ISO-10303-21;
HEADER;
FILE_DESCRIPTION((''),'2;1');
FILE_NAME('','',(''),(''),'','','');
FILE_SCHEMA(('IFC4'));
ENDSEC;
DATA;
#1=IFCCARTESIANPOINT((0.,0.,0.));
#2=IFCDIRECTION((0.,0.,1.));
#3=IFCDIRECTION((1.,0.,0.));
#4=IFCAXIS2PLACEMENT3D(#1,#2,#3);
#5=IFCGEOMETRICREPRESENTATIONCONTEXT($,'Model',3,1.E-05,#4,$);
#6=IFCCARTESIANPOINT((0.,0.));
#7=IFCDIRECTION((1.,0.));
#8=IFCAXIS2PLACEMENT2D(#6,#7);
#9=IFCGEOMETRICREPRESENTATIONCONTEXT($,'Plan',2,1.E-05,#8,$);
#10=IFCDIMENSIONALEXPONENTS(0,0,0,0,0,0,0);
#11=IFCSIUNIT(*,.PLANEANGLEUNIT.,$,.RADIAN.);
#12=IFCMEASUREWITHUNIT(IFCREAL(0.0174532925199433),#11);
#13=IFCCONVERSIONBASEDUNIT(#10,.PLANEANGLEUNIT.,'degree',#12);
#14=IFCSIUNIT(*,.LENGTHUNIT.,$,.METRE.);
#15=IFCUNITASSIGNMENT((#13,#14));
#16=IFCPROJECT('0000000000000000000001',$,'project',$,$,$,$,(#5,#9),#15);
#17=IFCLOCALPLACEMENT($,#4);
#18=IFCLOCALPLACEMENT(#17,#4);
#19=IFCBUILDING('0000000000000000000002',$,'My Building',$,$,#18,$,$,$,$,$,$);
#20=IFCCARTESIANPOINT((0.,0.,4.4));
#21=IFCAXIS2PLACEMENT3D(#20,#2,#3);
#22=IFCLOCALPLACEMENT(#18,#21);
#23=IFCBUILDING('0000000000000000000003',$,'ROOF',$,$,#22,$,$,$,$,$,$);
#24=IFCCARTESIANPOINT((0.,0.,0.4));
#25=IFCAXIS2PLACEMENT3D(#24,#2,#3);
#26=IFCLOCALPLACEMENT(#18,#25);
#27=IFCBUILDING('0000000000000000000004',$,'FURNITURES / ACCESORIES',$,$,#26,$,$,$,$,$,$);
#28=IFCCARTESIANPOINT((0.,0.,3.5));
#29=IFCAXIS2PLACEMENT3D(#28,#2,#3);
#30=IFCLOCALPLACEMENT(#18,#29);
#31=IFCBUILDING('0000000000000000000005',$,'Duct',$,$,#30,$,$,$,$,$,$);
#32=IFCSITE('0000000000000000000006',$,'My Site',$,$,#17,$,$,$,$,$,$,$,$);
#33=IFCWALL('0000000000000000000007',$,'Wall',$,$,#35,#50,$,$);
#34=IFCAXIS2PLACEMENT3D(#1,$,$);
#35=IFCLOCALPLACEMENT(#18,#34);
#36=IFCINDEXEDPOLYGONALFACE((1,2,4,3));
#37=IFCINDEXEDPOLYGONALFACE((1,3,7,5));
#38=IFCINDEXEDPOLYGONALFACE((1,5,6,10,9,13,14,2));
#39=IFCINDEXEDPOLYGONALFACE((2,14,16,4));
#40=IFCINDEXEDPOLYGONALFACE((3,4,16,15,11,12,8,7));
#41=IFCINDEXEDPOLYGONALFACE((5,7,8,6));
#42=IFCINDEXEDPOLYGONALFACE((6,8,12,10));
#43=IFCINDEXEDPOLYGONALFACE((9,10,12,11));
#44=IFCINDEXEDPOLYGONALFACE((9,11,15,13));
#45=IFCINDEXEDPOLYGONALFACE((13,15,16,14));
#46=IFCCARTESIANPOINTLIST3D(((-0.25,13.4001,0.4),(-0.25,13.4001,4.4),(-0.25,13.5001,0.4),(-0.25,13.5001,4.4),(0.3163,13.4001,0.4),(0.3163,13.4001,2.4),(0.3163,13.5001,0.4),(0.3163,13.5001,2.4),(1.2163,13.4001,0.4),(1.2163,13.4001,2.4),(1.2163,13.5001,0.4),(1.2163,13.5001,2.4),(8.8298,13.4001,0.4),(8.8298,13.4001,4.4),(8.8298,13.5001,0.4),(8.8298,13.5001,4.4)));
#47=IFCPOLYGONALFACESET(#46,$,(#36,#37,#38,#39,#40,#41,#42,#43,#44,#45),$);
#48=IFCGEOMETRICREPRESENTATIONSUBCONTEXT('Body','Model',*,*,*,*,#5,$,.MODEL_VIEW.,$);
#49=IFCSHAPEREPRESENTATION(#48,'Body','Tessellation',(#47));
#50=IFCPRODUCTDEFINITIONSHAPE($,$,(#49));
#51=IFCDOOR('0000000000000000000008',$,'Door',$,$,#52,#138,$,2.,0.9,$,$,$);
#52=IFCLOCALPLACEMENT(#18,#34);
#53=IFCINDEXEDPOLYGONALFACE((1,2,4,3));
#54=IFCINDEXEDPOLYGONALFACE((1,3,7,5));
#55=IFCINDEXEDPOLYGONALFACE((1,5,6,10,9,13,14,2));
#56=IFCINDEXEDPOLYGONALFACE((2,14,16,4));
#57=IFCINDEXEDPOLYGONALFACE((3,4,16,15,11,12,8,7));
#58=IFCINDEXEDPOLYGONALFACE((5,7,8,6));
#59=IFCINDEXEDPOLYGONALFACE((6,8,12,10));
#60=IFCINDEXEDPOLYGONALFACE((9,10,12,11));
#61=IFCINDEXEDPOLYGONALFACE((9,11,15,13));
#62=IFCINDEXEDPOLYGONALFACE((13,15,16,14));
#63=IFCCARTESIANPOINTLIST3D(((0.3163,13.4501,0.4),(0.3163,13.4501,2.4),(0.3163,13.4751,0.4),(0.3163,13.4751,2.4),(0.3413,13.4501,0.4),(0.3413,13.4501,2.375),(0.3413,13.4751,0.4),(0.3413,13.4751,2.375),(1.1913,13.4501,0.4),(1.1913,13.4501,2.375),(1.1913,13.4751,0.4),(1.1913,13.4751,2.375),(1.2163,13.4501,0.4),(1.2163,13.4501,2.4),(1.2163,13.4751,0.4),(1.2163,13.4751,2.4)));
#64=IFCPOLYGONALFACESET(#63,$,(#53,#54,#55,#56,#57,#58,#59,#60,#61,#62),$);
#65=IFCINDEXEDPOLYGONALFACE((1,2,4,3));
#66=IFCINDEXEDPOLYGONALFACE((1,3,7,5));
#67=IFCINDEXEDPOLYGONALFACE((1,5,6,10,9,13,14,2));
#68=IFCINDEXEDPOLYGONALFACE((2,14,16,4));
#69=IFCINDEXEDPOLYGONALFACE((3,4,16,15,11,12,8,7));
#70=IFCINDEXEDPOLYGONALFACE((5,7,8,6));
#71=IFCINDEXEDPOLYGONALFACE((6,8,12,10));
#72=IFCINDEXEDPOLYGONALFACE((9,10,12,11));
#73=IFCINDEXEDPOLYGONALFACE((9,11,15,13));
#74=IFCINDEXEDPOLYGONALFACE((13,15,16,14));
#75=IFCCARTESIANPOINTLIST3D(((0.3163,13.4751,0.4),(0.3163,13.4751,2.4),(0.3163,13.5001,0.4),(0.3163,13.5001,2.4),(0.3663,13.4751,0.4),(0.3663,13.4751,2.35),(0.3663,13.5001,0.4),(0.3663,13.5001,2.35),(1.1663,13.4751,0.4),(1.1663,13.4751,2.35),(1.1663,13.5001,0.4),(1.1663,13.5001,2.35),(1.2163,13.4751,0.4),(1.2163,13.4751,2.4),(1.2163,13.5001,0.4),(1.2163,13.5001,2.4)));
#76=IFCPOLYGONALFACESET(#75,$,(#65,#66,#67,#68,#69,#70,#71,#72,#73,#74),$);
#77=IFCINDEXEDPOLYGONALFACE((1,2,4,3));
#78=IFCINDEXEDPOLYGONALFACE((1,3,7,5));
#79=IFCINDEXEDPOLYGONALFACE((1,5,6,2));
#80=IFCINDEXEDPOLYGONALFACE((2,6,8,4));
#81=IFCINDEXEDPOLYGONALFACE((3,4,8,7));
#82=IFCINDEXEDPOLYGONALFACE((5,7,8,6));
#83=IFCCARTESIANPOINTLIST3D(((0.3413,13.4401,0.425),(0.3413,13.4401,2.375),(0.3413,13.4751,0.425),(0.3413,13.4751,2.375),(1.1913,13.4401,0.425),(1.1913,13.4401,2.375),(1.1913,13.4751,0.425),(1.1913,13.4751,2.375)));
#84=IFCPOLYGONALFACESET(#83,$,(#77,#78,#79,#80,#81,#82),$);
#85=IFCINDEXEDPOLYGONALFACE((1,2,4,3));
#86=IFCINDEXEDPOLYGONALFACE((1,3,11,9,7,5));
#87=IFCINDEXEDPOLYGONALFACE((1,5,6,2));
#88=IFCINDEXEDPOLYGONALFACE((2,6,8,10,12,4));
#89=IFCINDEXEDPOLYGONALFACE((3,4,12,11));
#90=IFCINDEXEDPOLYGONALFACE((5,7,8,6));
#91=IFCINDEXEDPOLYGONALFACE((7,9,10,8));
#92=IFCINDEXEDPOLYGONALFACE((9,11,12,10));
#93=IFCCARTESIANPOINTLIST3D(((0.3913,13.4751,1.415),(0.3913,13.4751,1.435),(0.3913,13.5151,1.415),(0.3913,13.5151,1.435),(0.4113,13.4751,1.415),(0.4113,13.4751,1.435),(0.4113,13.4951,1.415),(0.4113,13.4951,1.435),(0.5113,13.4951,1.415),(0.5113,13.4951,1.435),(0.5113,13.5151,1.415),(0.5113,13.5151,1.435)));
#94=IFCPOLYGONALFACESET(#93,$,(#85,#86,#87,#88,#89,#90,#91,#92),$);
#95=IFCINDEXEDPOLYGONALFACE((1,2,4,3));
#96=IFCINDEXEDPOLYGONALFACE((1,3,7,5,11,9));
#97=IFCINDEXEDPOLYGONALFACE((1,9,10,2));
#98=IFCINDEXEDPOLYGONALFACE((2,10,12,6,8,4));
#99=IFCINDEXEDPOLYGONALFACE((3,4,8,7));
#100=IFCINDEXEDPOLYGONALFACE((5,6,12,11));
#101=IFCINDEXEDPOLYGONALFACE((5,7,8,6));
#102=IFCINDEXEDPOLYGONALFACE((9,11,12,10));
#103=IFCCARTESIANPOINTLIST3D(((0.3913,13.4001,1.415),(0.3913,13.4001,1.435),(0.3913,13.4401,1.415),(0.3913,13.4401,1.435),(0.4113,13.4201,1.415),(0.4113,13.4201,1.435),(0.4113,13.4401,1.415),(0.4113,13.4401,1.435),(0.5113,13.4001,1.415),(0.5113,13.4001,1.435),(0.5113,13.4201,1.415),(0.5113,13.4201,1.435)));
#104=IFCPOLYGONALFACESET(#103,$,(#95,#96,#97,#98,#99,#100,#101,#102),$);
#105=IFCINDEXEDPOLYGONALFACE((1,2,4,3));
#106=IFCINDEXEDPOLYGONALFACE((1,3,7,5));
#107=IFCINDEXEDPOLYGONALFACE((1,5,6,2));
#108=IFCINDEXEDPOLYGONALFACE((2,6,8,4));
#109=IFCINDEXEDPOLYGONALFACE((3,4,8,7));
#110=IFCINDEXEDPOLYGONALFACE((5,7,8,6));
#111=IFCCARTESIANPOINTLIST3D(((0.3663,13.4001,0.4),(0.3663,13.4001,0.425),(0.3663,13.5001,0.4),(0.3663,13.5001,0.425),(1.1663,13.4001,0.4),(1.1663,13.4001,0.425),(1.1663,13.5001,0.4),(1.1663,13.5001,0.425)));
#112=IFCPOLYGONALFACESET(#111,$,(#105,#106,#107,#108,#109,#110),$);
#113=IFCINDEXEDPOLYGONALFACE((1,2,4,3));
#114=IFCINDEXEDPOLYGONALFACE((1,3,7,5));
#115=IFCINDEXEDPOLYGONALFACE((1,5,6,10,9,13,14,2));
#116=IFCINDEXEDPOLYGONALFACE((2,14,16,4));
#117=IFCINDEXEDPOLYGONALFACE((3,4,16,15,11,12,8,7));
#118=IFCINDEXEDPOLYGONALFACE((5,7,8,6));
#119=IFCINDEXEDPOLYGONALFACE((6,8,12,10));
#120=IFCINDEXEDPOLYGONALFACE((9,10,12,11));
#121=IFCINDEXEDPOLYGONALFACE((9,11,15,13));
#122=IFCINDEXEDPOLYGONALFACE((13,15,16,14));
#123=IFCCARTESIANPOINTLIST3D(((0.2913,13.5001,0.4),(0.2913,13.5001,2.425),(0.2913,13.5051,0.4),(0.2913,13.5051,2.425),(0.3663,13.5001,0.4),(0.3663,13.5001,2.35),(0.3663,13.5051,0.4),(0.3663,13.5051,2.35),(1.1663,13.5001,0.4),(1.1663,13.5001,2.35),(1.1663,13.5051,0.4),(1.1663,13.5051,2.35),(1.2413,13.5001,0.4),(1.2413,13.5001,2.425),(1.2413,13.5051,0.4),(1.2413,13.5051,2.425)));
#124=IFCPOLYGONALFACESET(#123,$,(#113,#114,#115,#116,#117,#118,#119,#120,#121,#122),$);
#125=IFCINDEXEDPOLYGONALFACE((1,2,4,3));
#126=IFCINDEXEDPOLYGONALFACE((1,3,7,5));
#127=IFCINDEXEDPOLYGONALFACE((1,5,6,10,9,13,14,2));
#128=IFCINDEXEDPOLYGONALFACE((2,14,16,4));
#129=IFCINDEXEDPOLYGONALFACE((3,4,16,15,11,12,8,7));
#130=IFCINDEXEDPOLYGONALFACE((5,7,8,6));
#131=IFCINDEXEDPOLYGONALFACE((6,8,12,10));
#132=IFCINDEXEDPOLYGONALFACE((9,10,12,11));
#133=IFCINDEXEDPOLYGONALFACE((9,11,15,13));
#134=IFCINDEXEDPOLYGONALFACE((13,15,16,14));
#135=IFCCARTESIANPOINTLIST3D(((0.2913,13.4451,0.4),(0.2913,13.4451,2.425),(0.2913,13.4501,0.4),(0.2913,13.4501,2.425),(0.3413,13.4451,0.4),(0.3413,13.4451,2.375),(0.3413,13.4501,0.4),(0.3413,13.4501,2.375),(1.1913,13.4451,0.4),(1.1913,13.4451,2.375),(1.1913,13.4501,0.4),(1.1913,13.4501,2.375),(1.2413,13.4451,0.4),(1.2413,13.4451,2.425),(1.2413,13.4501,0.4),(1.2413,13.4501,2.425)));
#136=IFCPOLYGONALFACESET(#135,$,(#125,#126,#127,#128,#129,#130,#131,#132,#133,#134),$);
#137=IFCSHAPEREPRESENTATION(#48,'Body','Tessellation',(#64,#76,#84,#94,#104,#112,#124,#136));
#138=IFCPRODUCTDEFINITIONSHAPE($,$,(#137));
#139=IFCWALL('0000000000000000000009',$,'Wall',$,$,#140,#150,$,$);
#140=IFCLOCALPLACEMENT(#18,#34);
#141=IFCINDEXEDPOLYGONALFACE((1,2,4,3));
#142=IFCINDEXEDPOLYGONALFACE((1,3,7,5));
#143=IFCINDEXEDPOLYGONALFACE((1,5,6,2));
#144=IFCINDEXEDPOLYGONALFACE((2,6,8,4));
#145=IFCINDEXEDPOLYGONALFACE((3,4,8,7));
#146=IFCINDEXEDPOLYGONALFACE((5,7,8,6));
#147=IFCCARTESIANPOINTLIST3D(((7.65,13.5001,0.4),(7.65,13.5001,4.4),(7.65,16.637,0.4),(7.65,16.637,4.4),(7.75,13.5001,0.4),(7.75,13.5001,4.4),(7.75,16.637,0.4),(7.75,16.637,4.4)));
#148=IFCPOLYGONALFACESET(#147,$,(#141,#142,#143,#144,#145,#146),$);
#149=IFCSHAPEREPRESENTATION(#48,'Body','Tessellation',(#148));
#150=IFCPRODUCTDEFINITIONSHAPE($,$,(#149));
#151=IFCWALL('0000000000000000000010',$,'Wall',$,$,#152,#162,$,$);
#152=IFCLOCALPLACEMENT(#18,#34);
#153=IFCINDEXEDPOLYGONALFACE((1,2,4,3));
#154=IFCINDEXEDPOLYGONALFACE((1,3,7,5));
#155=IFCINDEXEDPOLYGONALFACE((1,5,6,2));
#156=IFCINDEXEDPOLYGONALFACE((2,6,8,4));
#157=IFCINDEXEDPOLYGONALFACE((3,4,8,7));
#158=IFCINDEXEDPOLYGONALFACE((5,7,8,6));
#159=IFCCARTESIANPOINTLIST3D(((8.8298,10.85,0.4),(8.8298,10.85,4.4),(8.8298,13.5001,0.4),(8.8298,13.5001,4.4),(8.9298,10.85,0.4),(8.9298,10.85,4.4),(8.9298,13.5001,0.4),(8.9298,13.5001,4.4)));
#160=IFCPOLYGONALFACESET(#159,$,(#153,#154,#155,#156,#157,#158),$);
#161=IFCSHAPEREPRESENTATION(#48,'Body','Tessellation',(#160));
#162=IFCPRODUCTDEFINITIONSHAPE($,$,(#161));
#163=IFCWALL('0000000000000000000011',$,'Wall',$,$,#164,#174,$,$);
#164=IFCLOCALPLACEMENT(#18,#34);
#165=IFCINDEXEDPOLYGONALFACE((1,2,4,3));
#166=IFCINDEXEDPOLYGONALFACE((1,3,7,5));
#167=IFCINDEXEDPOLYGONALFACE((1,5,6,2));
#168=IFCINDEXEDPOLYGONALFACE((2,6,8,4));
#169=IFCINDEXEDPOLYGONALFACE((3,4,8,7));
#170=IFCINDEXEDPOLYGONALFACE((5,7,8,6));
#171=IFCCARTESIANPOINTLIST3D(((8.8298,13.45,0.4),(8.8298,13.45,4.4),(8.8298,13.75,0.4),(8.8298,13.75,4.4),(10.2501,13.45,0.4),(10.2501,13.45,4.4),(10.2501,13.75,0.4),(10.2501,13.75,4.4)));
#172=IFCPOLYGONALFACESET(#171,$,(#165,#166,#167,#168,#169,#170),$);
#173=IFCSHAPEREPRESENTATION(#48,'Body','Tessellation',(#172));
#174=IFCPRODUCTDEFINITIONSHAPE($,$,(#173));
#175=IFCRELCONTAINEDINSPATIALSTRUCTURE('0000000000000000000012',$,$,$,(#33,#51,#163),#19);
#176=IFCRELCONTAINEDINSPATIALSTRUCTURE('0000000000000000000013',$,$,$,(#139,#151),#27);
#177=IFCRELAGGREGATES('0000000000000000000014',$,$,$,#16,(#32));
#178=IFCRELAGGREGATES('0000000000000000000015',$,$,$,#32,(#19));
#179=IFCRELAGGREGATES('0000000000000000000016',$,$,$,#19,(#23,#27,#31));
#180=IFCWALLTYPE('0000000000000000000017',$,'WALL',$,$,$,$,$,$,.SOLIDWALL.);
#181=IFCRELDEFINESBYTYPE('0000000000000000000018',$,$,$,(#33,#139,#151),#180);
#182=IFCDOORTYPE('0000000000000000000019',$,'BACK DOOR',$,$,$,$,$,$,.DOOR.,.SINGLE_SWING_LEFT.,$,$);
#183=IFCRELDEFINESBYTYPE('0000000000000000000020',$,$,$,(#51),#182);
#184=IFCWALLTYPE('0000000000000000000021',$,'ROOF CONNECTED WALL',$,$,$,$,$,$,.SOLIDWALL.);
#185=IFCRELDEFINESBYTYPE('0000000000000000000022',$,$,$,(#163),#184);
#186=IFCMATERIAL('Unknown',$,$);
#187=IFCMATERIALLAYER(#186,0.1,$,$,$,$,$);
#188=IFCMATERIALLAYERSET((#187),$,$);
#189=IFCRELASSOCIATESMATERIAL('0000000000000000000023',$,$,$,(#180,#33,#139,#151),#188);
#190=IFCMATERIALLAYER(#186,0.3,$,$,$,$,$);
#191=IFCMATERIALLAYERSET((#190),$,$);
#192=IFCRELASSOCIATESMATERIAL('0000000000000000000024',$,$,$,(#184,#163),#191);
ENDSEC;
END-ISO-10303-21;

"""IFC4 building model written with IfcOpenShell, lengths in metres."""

from ifc_helpers import new_model, entity, si_unit, converted_unit, frame, origin_with_axes, origin_2d_with_axis, place, context, subcontext, project, spatial, line, indexed_curve, outline, extrude, shape, source, transform, mapped, material, layer, layer_set, layer_usage, type_object, type_shapes, element, fill, save


model = new_model("IFC4")

# Units and contexts
model_context = context("Model", 3, precision=1e-05, world=origin_with_axes())
plan_context = context("Plan", 2, precision=1e-05, world=origin_2d_with_axis())
body_context_1 = subcontext(model_context, "Body", "Model", "MODEL_VIEW")
body_context_2 = subcontext(plan_context, "Body", "Plan", "PLAN_VIEW")
ifc_project = project(units=[converted_unit("PLANEANGLEUNIT", "degree", entity("IfcReal", 0.0174532925199433), si_unit("PLANEANGLEUNIT", "RADIAN"), dimensions=[0, 0, 0, 0, 0, 0, 0]), si_unit("LENGTHUNIT", "METRE")], contexts=[model_context, plan_context])

# Site, building
site_placement = place(None, origin_with_axes())
site = spatial("IfcSite", under=ifc_project, at=site_placement, Name="My Site")
building_1_placement = place(site_placement, origin_with_axes())
building_1 = spatial("IfcBuilding", under=site, at=building_1_placement, Name="My Building")

# Shared definitions
ifc_material = material(Name="Unknown")

# Shared definitions
building_2_placement = place(building_1_placement, frame((0.0, 0.0, 4.4), z_axis=(0.0, 0.0, 1.0), x_axis=(1.0, 0.0, 0.0)))
building_2 = spatial("IfcBuilding", under=building_1, at=building_2_placement, Name="ROOF")

# Shared definitions
building_3_placement = place(building_1_placement, frame((0.0, 0.0, 0.4), z_axis=(0.0, 0.0, 1.0), x_axis=(1.0, 0.0, 0.0)))
building_3 = spatial("IfcBuilding", under=building_1, at=building_3_placement, Name="FURNITURES / ACCESORIES")

# Wall, opening, door
ifc_layer_1 = layer(ifc_material, 0.1)
ifc_layer_set_1 = layer_set([ifc_layer_1])
ifc_layer_usage_1 = layer_usage(ifc_layer_set_1, "AXIS2", "POSITIVE", 0.0)
wall_type_1 = type_object("IfcWallType", Name="WALL", PredefinedType="SOLIDWALL", material=ifc_layer_set_1)
wall_1_placement = place(building_1_placement, frame((8.8298, 13.5001, 0.4), z_axis=(0.0, 0.0, 1.0), x_axis=(-1.0, 0.0, 0.0)))
wall_1 = element("IfcWall", 1, at=wall_1_placement, inside=building_1, type_object=wall_type_1, material=ifc_layer_usage_1, Name="Wall", context=body_context_1, shape_type="SweptSolid", body=[
    extrude(outline(indexed_curve([(0.0, 0.0), (0.0, 0.1), (9.0798, 0.1), (9.0798, 0.0)], segments=[line(1, 2, 3, 4, 1)])), origin_with_axes(), (0.0, 0.0, 1.0), 4.0),
])
shared_shape_1 = source(origin_with_axes(), body_context_1, "Body", "SweptSolid", [
    extrude(outline(indexed_curve([(0.0, 0.0), (0.9, 0.0), (0.9, 2.0), (0.0, 2.0)], segments=[line(1, 2, 3, 4, 1)])), frame((0.0, -0.6, 0.0), z_axis=(0.0, -1.0, 0.0), x_axis=(1.0, 0.0, 0.0)), (0.0, 0.0, -1.0), 1.2),
])
opening_placement = place(wall_1_placement, frame((7.6135, 0.0, 0.0), z_axis=(0.0, 0.0, 1.0), x_axis=(1.0, 0.0, 0.0)))
opening = element("IfcOpeningElement", 2, at=opening_placement, cuts=wall_1, PredefinedType="OPENING", context=body_context_1, shape_type="MappedRepresentation", body=[
    mapped(shared_shape_1, transform((0.0, 0.0, 0.0), x_axis=(1.0, 0.0, 0.0), y_axis=(0.0, 1.0, 0.0), z_axis=(0.0, 0.0, 1.0), scale=1.0)),
])
door_type = type_object("IfcDoorType", Name="BACK DOOR", OperationType="SINGLE_SWING_LEFT", PredefinedType="DOOR")
shared_shape_2 = source(origin_with_axes(), body_context_1, "Body", "SweptSolid", [
    extrude(outline(indexed_curve([(0.0, 0.0), (0.0, 2.0), (0.9, 2.0), (0.9, 0.0), (0.875, 0.0), (0.875, 1.975), (0.025, 1.975), (0.025, 0.0)], segments=[line(1, 2, 3, 4, 5, 6, 7, 8, 1)])), frame((0.0, 0.025, 0.0), z_axis=(0.0, -1.0, 0.0), x_axis=(1.0, 0.0, 0.0)), (0.0, 0.0, -1.0), 0.025),
    extrude(outline(indexed_curve([(0.0, 0.0), (0.0, 2.0), (0.9, 2.0), (0.9, 0.0), (0.85, 0.0), (0.85, 1.95), (0.05, 1.95), (0.05, 0.0)], segments=[line(1, 2, 3, 4, 5, 6, 7, 8, 1)])), frame((0.0, 0.0, 0.0), z_axis=(0.0, -1.0, 0.0), x_axis=(1.0, 0.0, 0.0)), (0.0, 0.0, -1.0), 0.025),
    extrude(outline(indexed_curve([(0.0, 0.0), (0.85, 0.0), (0.85, 0.035), (0.0, 0.035)], segments=[line(1, 2, 3, 4, 1)])), frame((0.025, 0.025, 0.025), z_axis=(0.0, 0.0, 1.0), x_axis=(1.0, 0.0, 0.0)), (0.0, 0.0, 1.0), 1.95),
    extrude(outline(indexed_curve([(0.0, 0.0), (0.0, -0.04), (-0.12, -0.04), (-0.12, -0.02), (-0.02, -0.02), (-0.02, 0.0)], segments=[line(1, 2, 3, 4, 5, 6, 1)])), frame((0.825, 0.025, 1.015), z_axis=(0.0, 0.0, 1.0), x_axis=(1.0, 0.0, 0.0)), (0.0, 0.0, 1.0), 0.02),
    extrude(outline(indexed_curve([(0.0, 0.0), (0.0, 0.04), (-0.12, 0.04), (-0.12, 0.02), (-0.02, 0.02), (-0.02, 0.0)], segments=[line(1, 2, 3, 4, 5, 6, 1)])), frame((0.825, 0.06, 1.015), z_axis=(0.0, 0.0, 1.0), x_axis=(1.0, 0.0, 0.0)), (0.0, 0.0, 1.0), 0.02),
    extrude(outline(indexed_curve([(0.0, 0.0), (0.8, 0.0), (0.8, 0.1), (0.0, 0.1)], segments=[line(1, 2, 3, 4, 1)])), frame((0.05, 0.0, 0.0), z_axis=(0.0, 0.0, 1.0), x_axis=(1.0, 0.0, 0.0)), (0.0, 0.0, 1.0), 0.025),
    extrude(outline(indexed_curve([(0.0, 0.0), (0.0, 2.025), (0.95, 2.025), (0.95, 0.0), (0.875, 0.0), (0.875, 1.95), (0.075, 1.95), (0.075, 0.0)], segments=[line(1, 2, 3, 4, 5, 6, 7, 8, 1)])), frame((-0.025, -0.005, 0.0), z_axis=(0.0, -1.0, 0.0), x_axis=(1.0, 0.0, 0.0)), (0.0, 0.0, -1.0), 0.005),
    extrude(outline(indexed_curve([(0.0, 0.0), (0.0, 2.025), (0.95, 2.025), (0.95, 0.0), (0.9, 0.0), (0.9, 1.975), (0.05, 1.975), (0.05, 0.0)], segments=[line(1, 2, 3, 4, 5, 6, 7, 8, 1)])), frame((-0.025, 0.05, 0.0), z_axis=(0.0, -1.0, 0.0), x_axis=(1.0, 0.0, 0.0)), (0.0, 0.0, -1.0), 0.005),
])
shared_shape_3 = source(origin_with_axes(), body_context_2, "Body", "Curve2D", [
    entity("IfcIndexedPolyCurve", entity("IfcCartesianPointList2D", [[0.0, 0.0], [0.0, 0.05], [0.025, 0.05], [0.025, 0.025], [0.05, 0.025], [0.05, 0.0]]), [entity("IfcLineIndex", [1, 2, 3, 4, 5, 6, 1])]),
    entity("IfcIndexedPolyCurve", entity("IfcCartesianPointList2D", [[0.9, 0.0], [0.9, 0.05], [0.875, 0.05], [0.875, 0.025], [0.85, 0.025], [0.85, 0.0]]), [entity("IfcLineIndex", [1, 2, 3, 4, 5, 6, 1])]),
    entity("IfcTrimmedCurve", entity("IfcEllipse", entity("IfcAxis2Placement2D", entity("IfcCartesianPoint", [0.06, 0.05]), entity("IfcDirection", [1.0, 0.0])), 0.815, 0.85), [entity("IfcCartesianPoint", [0.875, 0.05])], [entity("IfcCartesianPoint", [0.06, 0.9])], True, "CARTESIAN"),
    entity("IfcIndexedPolyCurve", entity("IfcCartesianPointList2D", [[0.025, 0.05], [0.06, 0.05], [0.06, 0.9], [0.025, 0.9]]), [entity("IfcLineIndex", [1, 2, 3, 4, 1])]),
])
type_shapes(door_type, [shared_shape_2, shared_shape_3])
door_placement = place(opening_placement, frame((0.0, 0.0, 0.0), z_axis=(0.0, 0.0, 1.0), x_axis=(1.0, 0.0, 0.0)))
door = element("IfcDoor", 3, at=door_placement, inside=building_1, type_object=door_type, Name="Door", OverallHeight=2.0, OverallWidth=0.9, shapes=[
    shape(body_context_1, "Body", "MappedRepresentation", [mapped(shared_shape_2, transform((0.0, 0.0, 0.0), x_axis=(1.0, 0.0, 0.0), y_axis=(0.0, 1.0, 0.0), z_axis=(0.0, 0.0, 1.0), scale=1.0))]),
    shape(body_context_2, "Body", "MappedRepresentation", [mapped(shared_shape_3, transform((0.0, 0.0, 0.0), x_axis=(1.0, 0.0, 0.0), y_axis=(0.0, 1.0, 0.0), z_axis=(0.0, 0.0, 1.0), scale=1.0))]),
])
fill(opening, door)

# Walls
ifc_layer_usage_2 = layer_usage(ifc_layer_set_1, "AXIS2", "POSITIVE", 0.0)
wall_2_placement = place(building_3_placement, frame((7.65, 16.637, 0.0), z_axis=(0.0, 0.0, 1.0), x_axis=(0.0, -1.0, 0.0)))
element("IfcWall", 4, at=wall_2_placement, inside=building_3, type_object=wall_type_1, material=ifc_layer_usage_2, Name="Wall", context=body_context_1, shape_type="SweptSolid", body=[
    extrude(outline(indexed_curve([(0.0, 0.0), (0.0, 0.1), (3.137, 0.1), (3.137, 0.0)], segments=[line(1, 2, 3, 4, 1)])), origin_with_axes(), (0.0, 0.0, 1.0), 4.0),
])
ifc_layer_usage_3 = layer_usage(ifc_layer_set_1, "AXIS2", "POSITIVE", 0.0)
wall_3_placement = place(building_3_placement, frame((8.8298, 13.5001, 0.0), z_axis=(0.0, 0.0, 1.0), x_axis=(0.0, -1.0, 0.0)))
element("IfcWall", 5, at=wall_3_placement, inside=building_3, type_object=wall_type_1, material=ifc_layer_usage_3, Name="Wall", context=body_context_1, shape_type="SweptSolid", body=[
    extrude(outline(indexed_curve([(0.0, 0.0), (0.0, 0.1), (2.6501, 0.1), (2.6501, 0.0)], segments=[line(1, 2, 3, 4, 1)])), origin_with_axes(), (0.0, 0.0, 1.0), 4.0),
])
ifc_layer_2 = layer(ifc_material, 0.3)
ifc_layer_set_2 = layer_set([ifc_layer_2])
ifc_layer_usage_4 = layer_usage(ifc_layer_set_2, "AXIS2", "POSITIVE", 0.0)
wall_type_2 = type_object("IfcWallType", Name="ROOF CONNECTED WALL", PredefinedType="SOLIDWALL", material=ifc_layer_set_2)
wall_4_placement = place(building_1_placement, frame((8.8298, 13.45, 0.4), z_axis=(0.0, 0.0, 1.0), x_axis=(1.0, 0.0, 0.0)))
element("IfcWall", 6, at=wall_4_placement, inside=building_1, type_object=wall_type_2, material=ifc_layer_usage_4, Name="Wall", context=body_context_1, shape_type="SweptSolid", body=[
    extrude(outline(indexed_curve([(0.0, 0.0), (0.0, 0.3), (1.4203, 0.3), (1.4203, 0.0)], segments=[line(1, 2, 3, 4, 1)])), origin_with_axes(), (0.0, 0.0, 1.0), 4.0),
])

# Shared definitions
building_4_placement = place(building_1_placement, frame((0.0, 0.0, 3.5), z_axis=(0.0, 0.0, 1.0), x_axis=(1.0, 0.0, 0.0)))
building_4 = spatial("IfcBuilding", under=building_1, at=building_4_placement, Name="Duct")

save(model, "model.ifc")
